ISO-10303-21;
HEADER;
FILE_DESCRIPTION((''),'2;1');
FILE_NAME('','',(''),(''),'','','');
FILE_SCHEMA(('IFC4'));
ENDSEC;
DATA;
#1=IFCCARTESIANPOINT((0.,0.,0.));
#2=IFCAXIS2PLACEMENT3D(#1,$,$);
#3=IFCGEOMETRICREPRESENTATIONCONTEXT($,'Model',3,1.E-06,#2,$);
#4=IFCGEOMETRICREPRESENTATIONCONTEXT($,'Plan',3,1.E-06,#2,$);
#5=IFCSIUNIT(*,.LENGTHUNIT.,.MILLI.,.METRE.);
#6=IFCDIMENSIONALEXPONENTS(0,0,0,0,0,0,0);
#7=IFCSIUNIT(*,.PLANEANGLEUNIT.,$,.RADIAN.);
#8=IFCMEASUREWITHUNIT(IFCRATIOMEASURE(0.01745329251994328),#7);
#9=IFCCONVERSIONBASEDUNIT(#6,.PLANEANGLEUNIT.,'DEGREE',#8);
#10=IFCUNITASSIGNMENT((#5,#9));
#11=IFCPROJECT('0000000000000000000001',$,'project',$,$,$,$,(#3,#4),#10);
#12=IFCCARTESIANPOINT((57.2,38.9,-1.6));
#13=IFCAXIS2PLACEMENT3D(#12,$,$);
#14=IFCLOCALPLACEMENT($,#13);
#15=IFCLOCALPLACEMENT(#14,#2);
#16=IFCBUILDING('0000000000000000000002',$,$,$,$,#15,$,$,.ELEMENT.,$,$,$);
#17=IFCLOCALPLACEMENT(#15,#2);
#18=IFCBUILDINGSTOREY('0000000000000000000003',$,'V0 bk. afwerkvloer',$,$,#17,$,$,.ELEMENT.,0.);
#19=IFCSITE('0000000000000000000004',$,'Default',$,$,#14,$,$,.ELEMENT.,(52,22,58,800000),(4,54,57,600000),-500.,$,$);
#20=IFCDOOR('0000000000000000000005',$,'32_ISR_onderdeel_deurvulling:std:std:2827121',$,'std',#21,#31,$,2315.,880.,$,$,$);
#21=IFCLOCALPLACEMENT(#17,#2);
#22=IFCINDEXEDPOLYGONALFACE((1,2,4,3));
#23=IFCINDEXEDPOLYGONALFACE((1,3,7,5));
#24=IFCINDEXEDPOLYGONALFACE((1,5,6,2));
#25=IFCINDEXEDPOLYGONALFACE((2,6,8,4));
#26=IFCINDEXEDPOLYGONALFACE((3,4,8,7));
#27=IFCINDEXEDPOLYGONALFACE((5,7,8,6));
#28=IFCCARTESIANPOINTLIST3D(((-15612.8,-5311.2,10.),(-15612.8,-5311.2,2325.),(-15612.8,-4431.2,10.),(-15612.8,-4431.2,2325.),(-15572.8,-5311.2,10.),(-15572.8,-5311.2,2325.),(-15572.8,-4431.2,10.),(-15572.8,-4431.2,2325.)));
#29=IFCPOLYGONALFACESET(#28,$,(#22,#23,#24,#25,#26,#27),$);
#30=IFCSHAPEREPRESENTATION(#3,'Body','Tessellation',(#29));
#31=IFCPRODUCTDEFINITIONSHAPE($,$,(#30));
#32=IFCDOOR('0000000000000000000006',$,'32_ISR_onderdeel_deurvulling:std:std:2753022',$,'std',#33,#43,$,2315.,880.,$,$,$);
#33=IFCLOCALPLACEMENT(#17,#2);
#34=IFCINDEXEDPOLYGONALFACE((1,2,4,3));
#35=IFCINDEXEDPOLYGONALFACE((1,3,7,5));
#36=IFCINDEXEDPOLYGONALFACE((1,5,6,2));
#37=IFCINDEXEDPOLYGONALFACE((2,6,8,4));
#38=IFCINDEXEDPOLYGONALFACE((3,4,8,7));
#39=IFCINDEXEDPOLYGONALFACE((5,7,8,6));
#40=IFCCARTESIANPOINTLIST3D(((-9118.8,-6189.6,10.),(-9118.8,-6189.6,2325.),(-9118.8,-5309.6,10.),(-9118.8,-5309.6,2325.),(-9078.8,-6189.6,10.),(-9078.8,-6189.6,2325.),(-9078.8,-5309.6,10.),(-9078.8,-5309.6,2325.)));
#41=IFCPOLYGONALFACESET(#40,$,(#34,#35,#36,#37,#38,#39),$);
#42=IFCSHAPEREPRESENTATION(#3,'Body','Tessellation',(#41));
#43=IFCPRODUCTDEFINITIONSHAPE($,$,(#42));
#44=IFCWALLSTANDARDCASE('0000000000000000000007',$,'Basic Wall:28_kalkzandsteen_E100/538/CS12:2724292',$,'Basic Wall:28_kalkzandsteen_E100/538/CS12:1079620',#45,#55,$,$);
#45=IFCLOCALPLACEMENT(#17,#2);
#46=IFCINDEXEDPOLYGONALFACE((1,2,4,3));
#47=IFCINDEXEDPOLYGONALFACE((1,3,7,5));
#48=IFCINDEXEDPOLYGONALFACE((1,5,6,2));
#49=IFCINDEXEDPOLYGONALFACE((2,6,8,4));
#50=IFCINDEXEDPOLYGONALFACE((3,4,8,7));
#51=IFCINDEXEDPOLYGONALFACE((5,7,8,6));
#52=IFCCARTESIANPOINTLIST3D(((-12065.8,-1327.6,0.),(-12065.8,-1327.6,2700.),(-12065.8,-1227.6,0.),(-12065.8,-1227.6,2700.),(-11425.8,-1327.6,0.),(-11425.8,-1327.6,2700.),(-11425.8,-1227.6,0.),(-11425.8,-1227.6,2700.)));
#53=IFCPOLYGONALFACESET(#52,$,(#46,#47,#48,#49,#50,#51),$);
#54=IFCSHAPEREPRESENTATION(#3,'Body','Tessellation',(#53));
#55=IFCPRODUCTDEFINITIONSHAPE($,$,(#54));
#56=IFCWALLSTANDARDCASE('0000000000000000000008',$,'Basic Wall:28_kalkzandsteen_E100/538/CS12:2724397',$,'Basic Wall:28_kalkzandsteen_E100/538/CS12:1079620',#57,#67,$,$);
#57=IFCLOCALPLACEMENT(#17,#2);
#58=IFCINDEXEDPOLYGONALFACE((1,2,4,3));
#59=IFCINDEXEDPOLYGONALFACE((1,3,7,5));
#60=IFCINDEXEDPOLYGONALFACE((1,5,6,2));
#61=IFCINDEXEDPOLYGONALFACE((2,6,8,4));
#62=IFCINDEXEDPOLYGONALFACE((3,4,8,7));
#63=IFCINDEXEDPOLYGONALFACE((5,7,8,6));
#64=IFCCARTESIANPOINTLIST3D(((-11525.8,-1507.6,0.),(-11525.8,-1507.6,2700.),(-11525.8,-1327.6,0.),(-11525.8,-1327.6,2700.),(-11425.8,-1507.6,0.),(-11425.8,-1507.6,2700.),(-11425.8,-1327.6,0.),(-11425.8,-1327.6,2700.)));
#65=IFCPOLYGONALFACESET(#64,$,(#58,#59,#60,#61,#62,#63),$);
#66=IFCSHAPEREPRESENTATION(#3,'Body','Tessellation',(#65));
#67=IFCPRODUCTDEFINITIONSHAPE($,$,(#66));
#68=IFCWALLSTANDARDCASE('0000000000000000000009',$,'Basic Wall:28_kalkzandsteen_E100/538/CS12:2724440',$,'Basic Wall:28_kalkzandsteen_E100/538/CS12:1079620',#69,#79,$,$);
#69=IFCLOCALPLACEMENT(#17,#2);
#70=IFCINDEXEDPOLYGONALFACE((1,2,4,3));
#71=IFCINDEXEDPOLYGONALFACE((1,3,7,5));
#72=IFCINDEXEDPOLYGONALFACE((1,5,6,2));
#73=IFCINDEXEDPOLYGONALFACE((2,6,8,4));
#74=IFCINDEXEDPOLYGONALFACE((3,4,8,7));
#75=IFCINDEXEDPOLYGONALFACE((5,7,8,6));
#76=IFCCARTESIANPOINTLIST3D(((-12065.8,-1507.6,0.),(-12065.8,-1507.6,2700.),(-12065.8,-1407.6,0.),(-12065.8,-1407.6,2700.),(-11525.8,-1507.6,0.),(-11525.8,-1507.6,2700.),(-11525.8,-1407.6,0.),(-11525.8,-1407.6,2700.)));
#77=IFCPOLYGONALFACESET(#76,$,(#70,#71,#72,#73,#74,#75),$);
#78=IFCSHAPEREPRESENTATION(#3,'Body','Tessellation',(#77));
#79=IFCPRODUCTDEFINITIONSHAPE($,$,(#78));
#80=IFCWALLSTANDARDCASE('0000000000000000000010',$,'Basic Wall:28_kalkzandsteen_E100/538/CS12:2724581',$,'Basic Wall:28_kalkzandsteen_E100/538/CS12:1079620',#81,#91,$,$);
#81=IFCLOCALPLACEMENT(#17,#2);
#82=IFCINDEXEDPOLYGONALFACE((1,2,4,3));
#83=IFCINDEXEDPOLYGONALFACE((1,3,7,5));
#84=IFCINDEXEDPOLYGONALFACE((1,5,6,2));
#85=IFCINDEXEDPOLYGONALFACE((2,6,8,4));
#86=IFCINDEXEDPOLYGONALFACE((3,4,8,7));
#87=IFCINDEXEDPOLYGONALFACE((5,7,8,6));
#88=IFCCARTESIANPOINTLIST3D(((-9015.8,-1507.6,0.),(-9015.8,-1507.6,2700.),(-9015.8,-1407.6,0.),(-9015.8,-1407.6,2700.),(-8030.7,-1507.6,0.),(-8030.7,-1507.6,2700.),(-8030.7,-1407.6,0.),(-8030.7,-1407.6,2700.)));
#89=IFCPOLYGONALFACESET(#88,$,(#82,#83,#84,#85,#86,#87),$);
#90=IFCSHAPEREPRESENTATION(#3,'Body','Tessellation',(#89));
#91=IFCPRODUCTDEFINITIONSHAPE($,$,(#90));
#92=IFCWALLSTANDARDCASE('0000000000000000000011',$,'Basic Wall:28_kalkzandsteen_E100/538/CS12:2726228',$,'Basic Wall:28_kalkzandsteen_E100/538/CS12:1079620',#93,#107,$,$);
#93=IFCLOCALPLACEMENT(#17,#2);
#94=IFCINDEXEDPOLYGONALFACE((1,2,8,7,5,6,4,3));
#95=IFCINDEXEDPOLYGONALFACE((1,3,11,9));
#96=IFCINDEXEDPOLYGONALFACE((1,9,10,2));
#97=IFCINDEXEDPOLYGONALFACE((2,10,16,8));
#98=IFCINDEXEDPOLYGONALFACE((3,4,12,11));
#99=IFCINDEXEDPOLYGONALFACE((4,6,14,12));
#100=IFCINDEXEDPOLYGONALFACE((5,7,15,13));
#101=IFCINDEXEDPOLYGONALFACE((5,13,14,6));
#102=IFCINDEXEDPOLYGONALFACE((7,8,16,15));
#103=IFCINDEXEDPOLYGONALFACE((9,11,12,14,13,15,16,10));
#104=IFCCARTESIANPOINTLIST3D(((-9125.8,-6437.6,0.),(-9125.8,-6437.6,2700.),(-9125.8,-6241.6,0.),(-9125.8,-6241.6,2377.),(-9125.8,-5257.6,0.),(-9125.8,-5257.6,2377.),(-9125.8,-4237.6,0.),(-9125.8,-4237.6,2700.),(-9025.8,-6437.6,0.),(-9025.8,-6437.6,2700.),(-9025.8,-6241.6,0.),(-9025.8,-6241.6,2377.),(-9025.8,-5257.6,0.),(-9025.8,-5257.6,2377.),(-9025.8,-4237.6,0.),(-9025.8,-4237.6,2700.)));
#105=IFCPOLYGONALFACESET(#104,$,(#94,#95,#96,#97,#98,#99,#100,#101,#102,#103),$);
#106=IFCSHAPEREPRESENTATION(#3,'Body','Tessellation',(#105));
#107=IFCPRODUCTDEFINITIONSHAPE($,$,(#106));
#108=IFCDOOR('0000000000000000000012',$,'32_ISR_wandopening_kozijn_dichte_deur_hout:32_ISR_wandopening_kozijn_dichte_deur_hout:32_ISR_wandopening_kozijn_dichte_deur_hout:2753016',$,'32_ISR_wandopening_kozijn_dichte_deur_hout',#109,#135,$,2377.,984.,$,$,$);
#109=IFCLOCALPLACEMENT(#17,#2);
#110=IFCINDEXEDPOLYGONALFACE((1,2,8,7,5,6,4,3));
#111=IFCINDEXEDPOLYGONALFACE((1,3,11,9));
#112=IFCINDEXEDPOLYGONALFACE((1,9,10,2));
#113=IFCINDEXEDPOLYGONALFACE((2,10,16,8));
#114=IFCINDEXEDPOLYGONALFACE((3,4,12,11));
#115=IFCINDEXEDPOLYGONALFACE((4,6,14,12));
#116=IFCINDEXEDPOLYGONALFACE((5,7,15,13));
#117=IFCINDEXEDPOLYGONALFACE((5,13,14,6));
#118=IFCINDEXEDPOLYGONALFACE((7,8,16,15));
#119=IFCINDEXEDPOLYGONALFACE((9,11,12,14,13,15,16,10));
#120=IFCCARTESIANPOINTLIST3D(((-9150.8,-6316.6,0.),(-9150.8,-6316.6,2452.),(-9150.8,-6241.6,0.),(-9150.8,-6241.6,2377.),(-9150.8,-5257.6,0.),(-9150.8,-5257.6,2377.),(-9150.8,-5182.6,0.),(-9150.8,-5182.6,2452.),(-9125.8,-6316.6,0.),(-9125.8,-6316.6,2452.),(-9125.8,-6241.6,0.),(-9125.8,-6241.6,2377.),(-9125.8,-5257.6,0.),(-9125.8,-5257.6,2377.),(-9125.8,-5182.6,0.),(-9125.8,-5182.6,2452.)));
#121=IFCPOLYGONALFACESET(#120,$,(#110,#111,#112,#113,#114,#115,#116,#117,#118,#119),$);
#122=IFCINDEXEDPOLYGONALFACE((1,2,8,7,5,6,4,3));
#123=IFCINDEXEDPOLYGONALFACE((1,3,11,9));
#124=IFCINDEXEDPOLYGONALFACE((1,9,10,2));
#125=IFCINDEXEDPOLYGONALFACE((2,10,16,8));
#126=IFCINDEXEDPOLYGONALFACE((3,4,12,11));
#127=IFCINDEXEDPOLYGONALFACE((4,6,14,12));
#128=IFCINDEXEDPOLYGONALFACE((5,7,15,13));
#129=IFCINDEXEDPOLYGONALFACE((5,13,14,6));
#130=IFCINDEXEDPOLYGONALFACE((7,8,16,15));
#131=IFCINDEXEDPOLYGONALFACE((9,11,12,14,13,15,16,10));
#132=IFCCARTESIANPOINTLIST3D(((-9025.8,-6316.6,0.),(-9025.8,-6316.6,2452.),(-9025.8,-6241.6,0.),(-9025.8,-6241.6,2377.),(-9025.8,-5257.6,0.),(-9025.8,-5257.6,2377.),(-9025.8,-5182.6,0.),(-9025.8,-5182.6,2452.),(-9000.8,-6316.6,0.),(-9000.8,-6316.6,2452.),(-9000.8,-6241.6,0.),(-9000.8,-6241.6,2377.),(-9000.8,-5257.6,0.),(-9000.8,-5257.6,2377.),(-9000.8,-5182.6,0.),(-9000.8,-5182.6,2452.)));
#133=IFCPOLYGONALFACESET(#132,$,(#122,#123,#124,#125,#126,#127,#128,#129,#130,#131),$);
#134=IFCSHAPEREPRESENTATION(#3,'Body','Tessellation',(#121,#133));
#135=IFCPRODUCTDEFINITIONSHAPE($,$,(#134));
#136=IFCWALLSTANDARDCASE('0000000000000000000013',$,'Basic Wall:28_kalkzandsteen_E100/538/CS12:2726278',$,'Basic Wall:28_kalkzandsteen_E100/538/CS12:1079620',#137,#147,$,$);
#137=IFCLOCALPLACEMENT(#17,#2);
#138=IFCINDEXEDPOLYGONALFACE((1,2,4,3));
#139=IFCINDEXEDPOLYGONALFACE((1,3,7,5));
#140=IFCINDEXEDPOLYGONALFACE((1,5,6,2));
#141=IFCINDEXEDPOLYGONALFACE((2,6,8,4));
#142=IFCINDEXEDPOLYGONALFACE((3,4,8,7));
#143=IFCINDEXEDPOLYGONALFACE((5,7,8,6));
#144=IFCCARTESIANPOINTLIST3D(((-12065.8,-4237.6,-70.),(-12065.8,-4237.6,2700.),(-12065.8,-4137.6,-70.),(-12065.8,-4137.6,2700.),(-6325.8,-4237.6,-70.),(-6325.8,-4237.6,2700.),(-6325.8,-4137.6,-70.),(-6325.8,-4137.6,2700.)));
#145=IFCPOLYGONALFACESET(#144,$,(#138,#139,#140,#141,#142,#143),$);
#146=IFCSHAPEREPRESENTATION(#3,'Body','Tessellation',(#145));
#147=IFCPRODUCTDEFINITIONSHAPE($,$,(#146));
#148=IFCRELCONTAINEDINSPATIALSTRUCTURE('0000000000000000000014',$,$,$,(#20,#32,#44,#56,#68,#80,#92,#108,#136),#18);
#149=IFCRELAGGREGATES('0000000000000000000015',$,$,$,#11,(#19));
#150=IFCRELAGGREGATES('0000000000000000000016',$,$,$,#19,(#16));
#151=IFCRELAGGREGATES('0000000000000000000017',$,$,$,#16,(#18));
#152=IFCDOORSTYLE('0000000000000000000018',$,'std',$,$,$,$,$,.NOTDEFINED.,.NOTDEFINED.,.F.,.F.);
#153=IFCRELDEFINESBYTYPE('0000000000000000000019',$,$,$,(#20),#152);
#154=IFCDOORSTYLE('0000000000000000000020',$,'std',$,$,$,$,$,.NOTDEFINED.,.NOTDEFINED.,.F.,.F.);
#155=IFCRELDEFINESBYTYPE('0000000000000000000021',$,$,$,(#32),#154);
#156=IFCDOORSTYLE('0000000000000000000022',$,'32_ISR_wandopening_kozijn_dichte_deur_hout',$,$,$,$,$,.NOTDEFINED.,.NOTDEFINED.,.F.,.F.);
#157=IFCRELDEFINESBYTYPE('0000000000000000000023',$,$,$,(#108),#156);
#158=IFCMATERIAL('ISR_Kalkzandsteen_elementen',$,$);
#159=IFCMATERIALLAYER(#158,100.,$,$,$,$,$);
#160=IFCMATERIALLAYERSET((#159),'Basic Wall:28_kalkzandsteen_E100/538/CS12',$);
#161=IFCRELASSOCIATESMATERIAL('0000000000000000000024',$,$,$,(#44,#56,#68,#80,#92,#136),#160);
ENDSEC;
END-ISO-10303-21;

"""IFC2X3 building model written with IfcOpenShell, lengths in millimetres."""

from ifc_helpers import new_model, entity, si_unit, converted_unit, frame, frame_2d, origin, origin_2d_with_axis, place, context, project, spatial, polyline, rectangle, outline, extrude, source, transform, mapped, material, layer, layer_set, layer_usage, type_object, type_shapes, element, fill, save


model = new_model("IFC2X3")

# Units and contexts
model_context = context("Model", 3, precision=1e-06, world=origin())
plan_context = context("Plan", 3, precision=1e-06, world=origin())
ifc_project = project(units=[si_unit("LENGTHUNIT", "METRE", prefix="MILLI"), converted_unit("PLANEANGLEUNIT", "DEGREE", entity("IfcRatioMeasure", 0.01745329251994328), si_unit("PLANEANGLEUNIT", "RADIAN"), dimensions=[0, 0, 0, 0, 0, 0, 0])], contexts=[model_context, plan_context])

# Site, building, storey
site_placement = place(None, frame((57.2, 38.9, -1.6)))
site = spatial("IfcSite", under=ifc_project, at=site_placement, Name="Default", CompositionType="ELEMENT", RefLatitude=(52, 22, 58, 800000), RefLongitude=(4, 54, 57, 600000), RefElevation=-500.0)
building_placement = place(site_placement, origin())
building = spatial("IfcBuilding", under=site, at=building_placement, CompositionType="ELEMENT")
storey_placement = place(building_placement, origin())
storey = spatial("IfcBuildingStorey", under=building, at=storey_placement, Name="V0 bk. afwerkvloer", CompositionType="ELEMENT", Elevation=0.0)

# Doors
door_style_1 = type_object("IfcDoorStyle", Name="std", ConstructionType="NOTDEFINED", OperationType="NOTDEFINED", ParameterTakesPrecedence=False, Sizeable=False)
shared_shape_1 = source(origin(), model_context, "Body", "SweptSolid", [
    extrude(rectangle(XDim=880.0, YDim=40.0, at=origin_2d_with_axis()), frame((0.0, 34.0, 0.0)), (0.0, 0.0, 1.0), 2315.0),
])
type_shapes(door_style_1, [shared_shape_1])
door_1_placement = place(storey_placement, frame((-15558.8, -4871.2, 10.0), z_axis=(0.0, 0.0, 1.0), x_axis=(0.0, 1.0, 0.0)))
element("IfcDoor", 1, at=door_1_placement, inside=storey, type_object=door_style_1, Name="32_ISR_onderdeel_deurvulling:std:std:2827121", ObjectType="std", OverallHeight=2315.0, OverallWidth=880.0, context=model_context, shape_type="MappedRepresentation", body=[
    mapped(shared_shape_1, transform((0.0, 0.0, 0.0), scale=1.0)),
])
door_style_2 = type_object("IfcDoorStyle", Name="std", ConstructionType="NOTDEFINED", OperationType="NOTDEFINED", ParameterTakesPrecedence=False, Sizeable=False)
shared_shape_2 = source(origin(), model_context, "Body", "SweptSolid", [
    extrude(rectangle(XDim=40.0, YDim=880.0, at=origin_2d_with_axis()), frame((0.0, -34.0, 0.0), z_axis=(0.0, 0.0, 1.0), x_axis=(0.0, -1.0, 0.0)), (0.0, 0.0, 1.0), 2315.0),
])
type_shapes(door_style_2, [shared_shape_2])
door_2_placement = place(storey_placement, frame((-9132.8, -5749.6, 10.0), z_axis=(0.0, 0.0, 1.0), x_axis=(0.0, 1.0, 0.0)))
element("IfcDoor", 2, at=door_2_placement, inside=storey, type_object=door_style_2, Name="32_ISR_onderdeel_deurvulling:std:std:2753022", ObjectType="std", OverallHeight=2315.0, OverallWidth=880.0, context=model_context, shape_type="MappedRepresentation", body=[
    mapped(shared_shape_2, transform((0.0, 0.0, 0.0), scale=1.0)),
])

# Shared definitions
ifc_material = material(Name="ISR_Kalkzandsteen_elementen")
ifc_layer_1 = layer(ifc_material, 100.0)
ifc_layer_set_1 = layer_set([ifc_layer_1], Name="Basic Wall:28_kalkzandsteen_E100/538/CS12")

# Walls
ifc_layer_usage_1 = layer_usage(ifc_layer_set_1, "AXIS2", "NEGATIVE", 50.0)
wall_1_placement = place(storey_placement, frame((-12065.8, -1277.6, 0.0)))
element("IfcWallStandardCase", 3, at=wall_1_placement, inside=storey, material=ifc_layer_usage_1, Name="Basic Wall:28_kalkzandsteen_E100/538/CS12:2724292", ObjectType="Basic Wall:28_kalkzandsteen_E100/538/CS12:1079620", context=model_context, shape_type="SweptSolid", body=[
    extrude(rectangle(XDim=640.0, YDim=100.0, at=frame_2d((320.0, 0.0), x_axis=(-1.0, 0.0))), origin(), (0.0, 0.0, 1.0), 2700.0),
])
ifc_layer_usage_2 = layer_usage(ifc_layer_set_1, "AXIS2", "NEGATIVE", 50.0)
wall_2_placement = place(storey_placement, frame((-11475.8, -1327.6, 0.0), z_axis=(0.0, 0.0, 1.0), x_axis=(0.0, -1.0, 0.0)))
element("IfcWallStandardCase", 4, at=wall_2_placement, inside=storey, material=ifc_layer_usage_2, Name="Basic Wall:28_kalkzandsteen_E100/538/CS12:2724397", ObjectType="Basic Wall:28_kalkzandsteen_E100/538/CS12:1079620", context=model_context, shape_type="SweptSolid", body=[
    extrude(rectangle(XDim=180.0, YDim=100.0, at=frame_2d((90.0, 0.0), x_axis=(-1.0, 0.0))), origin(), (0.0, 0.0, 1.0), 2700.0),
])
ifc_layer_usage_3 = layer_usage(ifc_layer_set_1, "AXIS2", "NEGATIVE", 50.0)
wall_3_placement = place(storey_placement, frame((-11525.8, -1457.6, 0.0), z_axis=(0.0, 0.0, 1.0), x_axis=(-1.0, 0.0, 0.0)))
element("IfcWallStandardCase", 5, at=wall_3_placement, inside=storey, material=ifc_layer_usage_3, Name="Basic Wall:28_kalkzandsteen_E100/538/CS12:2724440", ObjectType="Basic Wall:28_kalkzandsteen_E100/538/CS12:1079620", context=model_context, shape_type="SweptSolid", body=[
    extrude(rectangle(XDim=540.0, YDim=100.0, at=frame_2d((270.0, 0.0), x_axis=(-1.0, 0.0))), origin(), (0.0, 0.0, 1.0), 2700.0),
])
ifc_layer_usage_4 = layer_usage(ifc_layer_set_1, "AXIS2", "POSITIVE", -50.0)
wall_4_placement = place(storey_placement, frame((-9015.8, -1457.6, 0.0)))
element("IfcWallStandardCase", 6, at=wall_4_placement, inside=storey, material=ifc_layer_usage_4, Name="Basic Wall:28_kalkzandsteen_E100/538/CS12:2724581", ObjectType="Basic Wall:28_kalkzandsteen_E100/538/CS12:1079620", context=model_context, shape_type="SweptSolid", body=[
    extrude(rectangle(XDim=985.2, YDim=100.0, at=frame_2d((492.6, 0.0), x_axis=(-1.0, 0.0))), origin(), (0.0, 0.0, 1.0), 2700.0),
])

# Wall, opening, door
ifc_layer_usage_5 = layer_usage(ifc_layer_set_1, "AXIS2", "NEGATIVE", 50.0)
wall_5_placement = place(storey_placement, frame((-9075.8, -6437.6, 0.0), z_axis=(0.0, 0.0, 1.0), x_axis=(0.0, 1.0, 0.0)))
wall_5 = element("IfcWallStandardCase", 7, at=wall_5_placement, inside=storey, material=ifc_layer_usage_5, Name="Basic Wall:28_kalkzandsteen_E100/538/CS12:2726228", ObjectType="Basic Wall:28_kalkzandsteen_E100/538/CS12:1079620", context=model_context, shape_type="SweptSolid", body=[
    extrude(rectangle(XDim=2200.0, YDim=100.0, at=frame_2d((1100.0, 0.0), x_axis=(-1.0, 0.0))), origin(), (0.0, 0.0, 1.0), 2700.0),
])
opening_1_placement = place(wall_5_placement, frame((196.0, -50.0, 0.0)))
opening_1 = element("IfcOpeningElement", 8, at=opening_1_placement, cuts=wall_5, ObjectType="Opening", context=model_context, shape_type="SweptSolid", body=[
    extrude(rectangle(XDim=2377.0, YDim=984.0, at=frame_2d((1188.5, 492.0), x_axis=(1.0, 0.0))), frame((0.0, 0.0, 0.0), z_axis=(0.0, 1.0, 0.0), x_axis=(0.0, 0.0, 1.0)), (0.0, 0.0, 1.0), 100.0),
])
door_style_3 = type_object("IfcDoorStyle", Name="32_ISR_wandopening_kozijn_dichte_deur_hout", ConstructionType="NOTDEFINED", OperationType="NOTDEFINED", ParameterTakesPrecedence=False, Sizeable=False)
shared_shape_3 = source(origin(), model_context, "Body", "SweptSolid", [
    extrude(outline(polyline([(-1169.7, 492.0), (1207.2, 492.0), (1207.2, 567.0), (-1244.7, 567.0), (-1244.7, -567.0), (1207.2, -567.0), (1207.2, -492.0), (-1169.7, -492.0), (-1169.7, 492.0)])), frame((492.0, 100.0, 1207.2), z_axis=(0.0, 1.0, 0.0), x_axis=(0.0, 0.0, -1.0)), (0.0, 0.0, 1.0), 25.0),
    extrude(outline(polyline([(-567.0, -1244.7), (567.0, -1244.7), (567.0, 1207.2), (492.0, 1207.2), (492.0, -1169.7), (-492.0, -1169.7), (-492.0, 1207.2), (-567.0, 1207.2), (-567.0, -1244.7)])), frame((492.0, -25.0, 1207.2), z_axis=(0.0, 1.0, 0.0), x_axis=(1.0, 0.0, 0.0)), (0.0, 0.0, 1.0), 25.0),
])
type_shapes(door_style_3, [shared_shape_3])
door_3_placement = place(opening_1_placement, origin())
door_3 = element("IfcDoor", 9, at=door_3_placement, inside=storey, type_object=door_style_3, Name="32_ISR_wandopening_kozijn_dichte_deur_hout:32_ISR_wandopening_kozijn_dichte_deur_hout:32_ISR_wandopening_kozijn_dichte_deur_hout:2753016", ObjectType="32_ISR_wandopening_kozijn_dichte_deur_hout", OverallHeight=2377.0, OverallWidth=984.0, context=model_context, shape_type="MappedRepresentation", body=[
    mapped(shared_shape_3, transform((0.0, 0.0, 0.0), scale=1.0)),
])
fill(opening_1, door_3)

# Wall
ifc_layer_usage_6 = layer_usage(ifc_layer_set_1, "AXIS2", "NEGATIVE", 50.0)
wall_6_placement = place(storey_placement, frame((-12065.8, -4187.6, -70.0)))
element("IfcWallStandardCase", 10, at=wall_6_placement, inside=storey, material=ifc_layer_usage_6, Name="Basic Wall:28_kalkzandsteen_E100/538/CS12:2726278", ObjectType="Basic Wall:28_kalkzandsteen_E100/538/CS12:1079620", context=model_context, shape_type="SweptSolid", body=[
    extrude(rectangle(XDim=5740.0, YDim=100.0, at=frame_2d((2870.0, 0.0), x_axis=(-1.0, 0.0))), origin(), (0.0, 0.0, 1.0), 2770.0),
])

save(model, "model.ifc")
